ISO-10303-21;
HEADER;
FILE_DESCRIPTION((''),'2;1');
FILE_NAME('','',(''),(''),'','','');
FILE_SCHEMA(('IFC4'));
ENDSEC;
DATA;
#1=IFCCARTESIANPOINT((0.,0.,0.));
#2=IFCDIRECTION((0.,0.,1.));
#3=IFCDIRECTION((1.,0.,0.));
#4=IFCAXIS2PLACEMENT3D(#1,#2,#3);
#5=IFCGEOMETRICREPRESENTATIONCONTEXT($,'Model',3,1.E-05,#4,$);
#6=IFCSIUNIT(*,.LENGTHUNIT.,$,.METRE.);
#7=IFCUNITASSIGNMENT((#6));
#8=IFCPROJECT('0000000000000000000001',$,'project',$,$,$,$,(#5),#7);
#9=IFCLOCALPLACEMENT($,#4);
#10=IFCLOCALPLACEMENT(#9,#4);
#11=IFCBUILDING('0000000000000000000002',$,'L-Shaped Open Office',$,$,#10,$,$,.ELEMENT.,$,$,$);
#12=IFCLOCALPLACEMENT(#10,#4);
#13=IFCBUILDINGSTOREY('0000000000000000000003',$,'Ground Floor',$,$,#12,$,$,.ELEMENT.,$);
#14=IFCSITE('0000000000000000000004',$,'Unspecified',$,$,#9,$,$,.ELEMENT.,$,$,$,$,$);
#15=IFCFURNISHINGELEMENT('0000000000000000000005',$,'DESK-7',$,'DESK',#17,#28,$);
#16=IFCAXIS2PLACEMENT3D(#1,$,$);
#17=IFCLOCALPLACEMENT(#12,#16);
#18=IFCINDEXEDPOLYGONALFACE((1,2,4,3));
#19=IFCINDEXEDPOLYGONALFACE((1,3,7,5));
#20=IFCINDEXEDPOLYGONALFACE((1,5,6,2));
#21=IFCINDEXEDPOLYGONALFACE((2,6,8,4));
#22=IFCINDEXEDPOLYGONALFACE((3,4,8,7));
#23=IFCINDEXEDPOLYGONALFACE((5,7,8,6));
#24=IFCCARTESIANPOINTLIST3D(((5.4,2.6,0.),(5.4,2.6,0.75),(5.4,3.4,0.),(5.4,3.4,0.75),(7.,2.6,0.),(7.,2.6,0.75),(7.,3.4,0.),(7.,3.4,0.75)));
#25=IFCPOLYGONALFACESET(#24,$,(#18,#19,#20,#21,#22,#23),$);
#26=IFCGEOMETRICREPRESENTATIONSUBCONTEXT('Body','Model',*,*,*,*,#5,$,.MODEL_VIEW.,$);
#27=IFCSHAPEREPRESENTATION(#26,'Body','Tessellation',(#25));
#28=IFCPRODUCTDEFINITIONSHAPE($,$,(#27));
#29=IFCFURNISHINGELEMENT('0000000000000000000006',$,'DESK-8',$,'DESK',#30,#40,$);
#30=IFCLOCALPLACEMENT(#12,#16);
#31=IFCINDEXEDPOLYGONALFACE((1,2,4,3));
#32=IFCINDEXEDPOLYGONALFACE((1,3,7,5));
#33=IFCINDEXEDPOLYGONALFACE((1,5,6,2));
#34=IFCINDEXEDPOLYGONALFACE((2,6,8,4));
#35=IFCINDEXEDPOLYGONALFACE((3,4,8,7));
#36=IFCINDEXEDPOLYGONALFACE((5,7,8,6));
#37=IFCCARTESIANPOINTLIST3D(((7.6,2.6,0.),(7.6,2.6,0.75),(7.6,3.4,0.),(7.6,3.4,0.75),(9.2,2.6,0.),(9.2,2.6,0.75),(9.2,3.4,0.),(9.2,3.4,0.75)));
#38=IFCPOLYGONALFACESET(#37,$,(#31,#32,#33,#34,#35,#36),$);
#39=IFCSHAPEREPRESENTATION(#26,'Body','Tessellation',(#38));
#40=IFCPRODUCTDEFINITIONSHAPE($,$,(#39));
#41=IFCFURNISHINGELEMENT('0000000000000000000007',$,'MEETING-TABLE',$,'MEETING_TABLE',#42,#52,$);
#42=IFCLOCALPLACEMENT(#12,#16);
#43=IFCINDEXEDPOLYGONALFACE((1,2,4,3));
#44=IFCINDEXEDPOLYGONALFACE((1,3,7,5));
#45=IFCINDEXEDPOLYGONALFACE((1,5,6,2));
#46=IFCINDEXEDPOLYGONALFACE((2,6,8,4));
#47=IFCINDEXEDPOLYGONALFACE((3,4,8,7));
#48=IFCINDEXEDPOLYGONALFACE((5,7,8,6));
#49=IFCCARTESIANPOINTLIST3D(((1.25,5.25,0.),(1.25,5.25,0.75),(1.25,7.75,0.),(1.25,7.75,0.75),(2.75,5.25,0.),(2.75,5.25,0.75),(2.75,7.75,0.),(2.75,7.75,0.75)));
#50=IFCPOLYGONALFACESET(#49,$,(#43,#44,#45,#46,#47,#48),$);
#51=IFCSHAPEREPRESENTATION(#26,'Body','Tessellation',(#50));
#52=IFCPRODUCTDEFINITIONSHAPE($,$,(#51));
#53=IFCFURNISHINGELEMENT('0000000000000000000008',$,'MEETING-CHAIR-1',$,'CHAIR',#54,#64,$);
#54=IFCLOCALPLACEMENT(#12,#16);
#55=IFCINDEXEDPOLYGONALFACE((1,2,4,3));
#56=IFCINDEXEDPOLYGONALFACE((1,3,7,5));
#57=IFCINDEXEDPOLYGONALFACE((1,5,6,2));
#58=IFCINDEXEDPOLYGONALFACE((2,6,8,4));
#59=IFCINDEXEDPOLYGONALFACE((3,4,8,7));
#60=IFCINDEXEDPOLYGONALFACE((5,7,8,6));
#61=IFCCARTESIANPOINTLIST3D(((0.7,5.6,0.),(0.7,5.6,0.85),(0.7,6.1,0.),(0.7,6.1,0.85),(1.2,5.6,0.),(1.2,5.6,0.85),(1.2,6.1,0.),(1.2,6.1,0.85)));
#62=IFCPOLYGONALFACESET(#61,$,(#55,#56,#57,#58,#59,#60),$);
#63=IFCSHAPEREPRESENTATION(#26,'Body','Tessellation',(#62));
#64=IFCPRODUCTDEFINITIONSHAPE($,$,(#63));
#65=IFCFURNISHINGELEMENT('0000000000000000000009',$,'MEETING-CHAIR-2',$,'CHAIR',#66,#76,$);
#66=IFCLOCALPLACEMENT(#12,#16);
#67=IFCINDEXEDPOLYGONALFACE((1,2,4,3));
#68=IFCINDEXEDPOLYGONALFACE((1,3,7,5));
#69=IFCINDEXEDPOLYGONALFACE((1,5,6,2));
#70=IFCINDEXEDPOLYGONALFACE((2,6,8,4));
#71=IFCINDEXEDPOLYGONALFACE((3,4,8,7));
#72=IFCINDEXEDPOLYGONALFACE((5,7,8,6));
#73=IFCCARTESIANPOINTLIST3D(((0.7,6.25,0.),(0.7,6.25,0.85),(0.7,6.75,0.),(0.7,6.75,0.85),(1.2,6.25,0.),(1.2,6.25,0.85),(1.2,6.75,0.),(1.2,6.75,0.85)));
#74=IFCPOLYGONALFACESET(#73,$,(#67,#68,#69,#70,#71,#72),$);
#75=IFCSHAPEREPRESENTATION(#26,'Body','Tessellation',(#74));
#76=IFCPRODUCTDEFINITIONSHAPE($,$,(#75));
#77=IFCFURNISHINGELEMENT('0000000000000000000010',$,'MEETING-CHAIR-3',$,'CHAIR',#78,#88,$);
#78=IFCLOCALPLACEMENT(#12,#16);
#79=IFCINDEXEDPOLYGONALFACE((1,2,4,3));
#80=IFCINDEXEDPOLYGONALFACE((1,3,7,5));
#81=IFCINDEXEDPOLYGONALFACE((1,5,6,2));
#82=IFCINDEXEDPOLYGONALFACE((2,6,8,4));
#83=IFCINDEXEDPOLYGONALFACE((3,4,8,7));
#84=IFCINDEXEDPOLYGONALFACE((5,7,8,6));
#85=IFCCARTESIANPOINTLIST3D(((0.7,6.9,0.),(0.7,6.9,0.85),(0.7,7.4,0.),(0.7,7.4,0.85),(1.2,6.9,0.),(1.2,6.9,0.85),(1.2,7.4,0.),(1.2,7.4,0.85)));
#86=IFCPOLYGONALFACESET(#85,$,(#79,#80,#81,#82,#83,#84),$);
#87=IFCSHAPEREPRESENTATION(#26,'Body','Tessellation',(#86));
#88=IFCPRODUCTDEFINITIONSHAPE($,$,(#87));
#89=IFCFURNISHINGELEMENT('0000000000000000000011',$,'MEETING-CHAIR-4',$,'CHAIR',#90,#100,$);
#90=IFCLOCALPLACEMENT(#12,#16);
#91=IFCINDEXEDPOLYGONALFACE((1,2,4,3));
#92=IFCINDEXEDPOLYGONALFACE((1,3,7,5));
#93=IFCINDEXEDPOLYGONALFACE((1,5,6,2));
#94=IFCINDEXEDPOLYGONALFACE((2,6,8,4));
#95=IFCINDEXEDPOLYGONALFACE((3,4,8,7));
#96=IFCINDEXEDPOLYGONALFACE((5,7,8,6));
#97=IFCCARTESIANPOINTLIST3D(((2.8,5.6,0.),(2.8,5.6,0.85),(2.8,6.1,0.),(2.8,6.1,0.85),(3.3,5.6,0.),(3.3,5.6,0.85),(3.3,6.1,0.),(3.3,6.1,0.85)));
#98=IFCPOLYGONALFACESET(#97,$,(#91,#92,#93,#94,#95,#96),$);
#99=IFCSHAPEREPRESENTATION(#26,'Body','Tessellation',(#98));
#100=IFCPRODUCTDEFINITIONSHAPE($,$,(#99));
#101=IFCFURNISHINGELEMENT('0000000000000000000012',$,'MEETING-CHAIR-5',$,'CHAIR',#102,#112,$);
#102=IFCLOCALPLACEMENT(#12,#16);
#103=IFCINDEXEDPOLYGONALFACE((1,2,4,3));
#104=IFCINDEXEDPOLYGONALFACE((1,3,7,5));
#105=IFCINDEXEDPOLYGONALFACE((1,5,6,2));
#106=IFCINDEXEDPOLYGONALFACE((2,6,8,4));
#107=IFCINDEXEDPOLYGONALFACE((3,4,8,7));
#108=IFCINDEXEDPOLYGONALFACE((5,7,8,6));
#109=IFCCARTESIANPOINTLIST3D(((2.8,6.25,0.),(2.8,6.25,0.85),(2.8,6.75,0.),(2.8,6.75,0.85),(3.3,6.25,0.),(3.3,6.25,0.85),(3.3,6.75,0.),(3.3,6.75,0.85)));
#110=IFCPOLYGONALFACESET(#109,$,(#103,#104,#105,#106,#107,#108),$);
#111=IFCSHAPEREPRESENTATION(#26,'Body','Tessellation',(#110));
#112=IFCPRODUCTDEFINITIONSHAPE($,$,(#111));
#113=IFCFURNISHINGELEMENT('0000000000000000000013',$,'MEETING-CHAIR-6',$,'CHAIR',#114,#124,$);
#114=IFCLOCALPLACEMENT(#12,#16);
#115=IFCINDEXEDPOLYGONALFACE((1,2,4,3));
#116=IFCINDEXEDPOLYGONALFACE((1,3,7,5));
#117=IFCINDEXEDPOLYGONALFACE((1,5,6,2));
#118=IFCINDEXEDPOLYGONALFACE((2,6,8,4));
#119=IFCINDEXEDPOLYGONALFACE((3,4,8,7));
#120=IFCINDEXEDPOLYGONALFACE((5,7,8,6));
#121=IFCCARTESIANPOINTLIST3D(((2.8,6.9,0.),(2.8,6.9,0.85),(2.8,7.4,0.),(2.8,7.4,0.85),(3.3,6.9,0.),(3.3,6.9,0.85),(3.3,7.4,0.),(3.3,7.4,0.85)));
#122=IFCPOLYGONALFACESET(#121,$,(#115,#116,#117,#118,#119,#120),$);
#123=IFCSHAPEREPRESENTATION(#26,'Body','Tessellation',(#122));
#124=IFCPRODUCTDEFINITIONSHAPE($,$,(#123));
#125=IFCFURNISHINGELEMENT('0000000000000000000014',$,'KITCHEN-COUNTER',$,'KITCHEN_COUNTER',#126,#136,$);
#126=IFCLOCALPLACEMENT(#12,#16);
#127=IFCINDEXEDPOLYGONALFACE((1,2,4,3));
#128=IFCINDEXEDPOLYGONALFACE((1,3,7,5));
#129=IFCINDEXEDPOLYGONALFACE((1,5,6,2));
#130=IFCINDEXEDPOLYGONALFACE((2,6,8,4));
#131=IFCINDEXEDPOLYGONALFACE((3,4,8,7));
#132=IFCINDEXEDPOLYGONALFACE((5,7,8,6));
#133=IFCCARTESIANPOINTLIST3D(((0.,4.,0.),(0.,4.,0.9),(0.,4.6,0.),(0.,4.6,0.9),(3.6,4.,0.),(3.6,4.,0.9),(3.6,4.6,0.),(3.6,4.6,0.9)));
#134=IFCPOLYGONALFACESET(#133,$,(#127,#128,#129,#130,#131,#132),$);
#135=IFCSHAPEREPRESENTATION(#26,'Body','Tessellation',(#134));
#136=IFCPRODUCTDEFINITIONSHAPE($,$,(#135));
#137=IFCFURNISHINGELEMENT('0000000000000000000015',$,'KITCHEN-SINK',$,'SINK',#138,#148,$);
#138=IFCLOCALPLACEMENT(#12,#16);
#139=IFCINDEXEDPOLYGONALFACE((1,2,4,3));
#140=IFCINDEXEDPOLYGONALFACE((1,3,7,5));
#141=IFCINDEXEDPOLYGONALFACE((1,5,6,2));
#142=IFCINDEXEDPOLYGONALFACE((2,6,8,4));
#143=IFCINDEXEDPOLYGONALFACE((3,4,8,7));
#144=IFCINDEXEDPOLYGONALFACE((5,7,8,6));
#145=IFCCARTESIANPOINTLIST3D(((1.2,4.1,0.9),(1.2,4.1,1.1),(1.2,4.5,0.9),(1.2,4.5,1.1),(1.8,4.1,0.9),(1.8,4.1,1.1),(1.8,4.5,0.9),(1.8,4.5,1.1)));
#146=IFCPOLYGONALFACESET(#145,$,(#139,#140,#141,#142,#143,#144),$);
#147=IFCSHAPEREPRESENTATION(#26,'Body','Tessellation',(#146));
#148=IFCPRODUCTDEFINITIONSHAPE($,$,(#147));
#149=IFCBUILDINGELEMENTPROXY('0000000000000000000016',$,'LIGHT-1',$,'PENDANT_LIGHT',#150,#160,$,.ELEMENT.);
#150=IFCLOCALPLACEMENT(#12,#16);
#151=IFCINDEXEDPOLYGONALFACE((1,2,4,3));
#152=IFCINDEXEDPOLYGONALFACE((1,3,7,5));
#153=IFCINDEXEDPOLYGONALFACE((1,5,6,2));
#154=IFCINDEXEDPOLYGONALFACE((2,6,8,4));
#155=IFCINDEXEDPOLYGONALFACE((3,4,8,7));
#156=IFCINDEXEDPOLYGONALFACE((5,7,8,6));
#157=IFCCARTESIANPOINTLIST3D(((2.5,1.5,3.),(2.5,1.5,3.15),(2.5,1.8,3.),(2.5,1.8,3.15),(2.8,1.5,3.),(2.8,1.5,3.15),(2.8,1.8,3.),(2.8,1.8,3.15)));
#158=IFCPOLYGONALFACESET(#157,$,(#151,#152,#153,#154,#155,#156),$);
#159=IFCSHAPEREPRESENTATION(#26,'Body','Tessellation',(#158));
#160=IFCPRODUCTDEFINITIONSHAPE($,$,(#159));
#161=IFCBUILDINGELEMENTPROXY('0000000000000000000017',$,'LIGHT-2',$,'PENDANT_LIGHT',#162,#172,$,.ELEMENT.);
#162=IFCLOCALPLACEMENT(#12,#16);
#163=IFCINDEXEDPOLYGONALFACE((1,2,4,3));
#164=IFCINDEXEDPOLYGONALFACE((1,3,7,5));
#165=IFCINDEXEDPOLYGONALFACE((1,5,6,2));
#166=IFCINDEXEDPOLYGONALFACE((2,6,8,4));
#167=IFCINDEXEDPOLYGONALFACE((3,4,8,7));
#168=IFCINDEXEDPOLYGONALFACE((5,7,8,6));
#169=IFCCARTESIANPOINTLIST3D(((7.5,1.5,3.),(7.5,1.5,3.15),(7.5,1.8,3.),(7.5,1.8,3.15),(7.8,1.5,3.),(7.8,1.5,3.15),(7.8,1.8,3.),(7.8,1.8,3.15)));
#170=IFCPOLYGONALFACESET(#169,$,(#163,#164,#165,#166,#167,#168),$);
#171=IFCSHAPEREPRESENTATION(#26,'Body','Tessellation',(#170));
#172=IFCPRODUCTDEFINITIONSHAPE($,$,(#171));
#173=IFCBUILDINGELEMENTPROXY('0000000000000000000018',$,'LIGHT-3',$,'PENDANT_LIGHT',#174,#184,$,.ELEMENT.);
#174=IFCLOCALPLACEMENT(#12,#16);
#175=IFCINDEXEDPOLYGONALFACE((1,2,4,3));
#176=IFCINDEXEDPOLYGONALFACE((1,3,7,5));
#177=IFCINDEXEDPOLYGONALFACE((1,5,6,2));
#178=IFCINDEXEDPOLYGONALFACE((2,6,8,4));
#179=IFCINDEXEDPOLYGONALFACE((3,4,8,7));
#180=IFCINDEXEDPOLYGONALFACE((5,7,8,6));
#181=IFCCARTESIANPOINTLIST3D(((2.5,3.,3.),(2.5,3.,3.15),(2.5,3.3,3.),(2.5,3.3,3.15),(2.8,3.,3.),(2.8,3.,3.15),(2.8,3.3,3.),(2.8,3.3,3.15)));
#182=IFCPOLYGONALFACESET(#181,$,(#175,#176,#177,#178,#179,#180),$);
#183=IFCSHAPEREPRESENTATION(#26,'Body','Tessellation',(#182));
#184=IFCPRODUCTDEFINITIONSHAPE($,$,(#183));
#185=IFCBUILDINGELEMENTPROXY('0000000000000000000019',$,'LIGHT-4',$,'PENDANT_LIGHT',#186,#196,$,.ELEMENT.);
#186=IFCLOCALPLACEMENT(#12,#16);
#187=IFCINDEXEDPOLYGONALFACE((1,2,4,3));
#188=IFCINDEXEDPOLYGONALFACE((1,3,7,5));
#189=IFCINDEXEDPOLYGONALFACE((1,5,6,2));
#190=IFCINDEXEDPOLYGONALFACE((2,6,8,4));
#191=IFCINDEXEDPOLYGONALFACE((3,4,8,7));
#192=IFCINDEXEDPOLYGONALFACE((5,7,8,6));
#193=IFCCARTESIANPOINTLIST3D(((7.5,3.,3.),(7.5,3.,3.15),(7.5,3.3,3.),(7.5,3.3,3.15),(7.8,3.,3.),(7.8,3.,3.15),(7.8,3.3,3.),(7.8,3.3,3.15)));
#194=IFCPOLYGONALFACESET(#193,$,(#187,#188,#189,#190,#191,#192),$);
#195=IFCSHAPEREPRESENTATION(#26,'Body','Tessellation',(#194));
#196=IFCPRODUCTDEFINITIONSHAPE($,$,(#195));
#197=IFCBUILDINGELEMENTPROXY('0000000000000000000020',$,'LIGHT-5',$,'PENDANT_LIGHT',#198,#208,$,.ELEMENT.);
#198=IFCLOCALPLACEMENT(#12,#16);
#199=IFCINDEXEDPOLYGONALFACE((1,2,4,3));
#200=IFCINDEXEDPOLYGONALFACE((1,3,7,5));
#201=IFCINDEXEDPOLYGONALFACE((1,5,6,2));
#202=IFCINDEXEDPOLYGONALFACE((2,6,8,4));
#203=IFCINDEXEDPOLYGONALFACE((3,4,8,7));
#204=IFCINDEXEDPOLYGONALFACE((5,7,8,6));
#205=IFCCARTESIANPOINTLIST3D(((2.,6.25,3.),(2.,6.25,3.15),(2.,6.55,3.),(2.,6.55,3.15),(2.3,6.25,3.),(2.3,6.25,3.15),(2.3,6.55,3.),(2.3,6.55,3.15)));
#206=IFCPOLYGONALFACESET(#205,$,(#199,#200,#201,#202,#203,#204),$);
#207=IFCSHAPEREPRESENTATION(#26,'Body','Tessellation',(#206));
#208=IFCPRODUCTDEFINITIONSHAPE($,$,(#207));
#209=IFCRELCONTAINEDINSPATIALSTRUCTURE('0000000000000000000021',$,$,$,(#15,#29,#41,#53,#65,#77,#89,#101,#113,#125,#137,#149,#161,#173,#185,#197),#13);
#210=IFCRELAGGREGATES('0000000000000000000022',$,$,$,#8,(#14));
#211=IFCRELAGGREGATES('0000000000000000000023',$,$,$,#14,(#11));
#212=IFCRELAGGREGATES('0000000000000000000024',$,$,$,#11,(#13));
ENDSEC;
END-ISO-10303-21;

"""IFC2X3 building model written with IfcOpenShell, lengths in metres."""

from ifc_helpers import new_model, si_unit, frame, frame_2d, origin, origin_with_axes, place, context, subcontext, project, spatial, rectangle, extrude, element, save


model = new_model("IFC2X3")

# Units and contexts
model_context = context("Model", 3, precision=1e-05, world=origin_with_axes())
body_context = subcontext(model_context, "Body", "Model", "MODEL_VIEW")
ifc_project = project(units=[si_unit("LENGTHUNIT", "METRE")], contexts=[model_context])

# Site, building, storey
site_placement = place(None, origin_with_axes())
site = spatial("IfcSite", under=ifc_project, at=site_placement, Name="Unspecified", CompositionType="ELEMENT")
building_placement = place(site_placement, origin_with_axes())
building = spatial("IfcBuilding", under=site, at=building_placement, Name="L-Shaped Open Office", CompositionType="ELEMENT")
storey_placement = place(building_placement, origin_with_axes())
storey = spatial("IfcBuildingStorey", under=building, at=storey_placement, Name="Ground Floor", CompositionType="ELEMENT")

# Furnishing elements
for number, where, z_axis, x_axis, name in (
    (1, (5.4, 2.6, 0.0), (0.0, 0.0, 1.0), (1.0, 0.0, 0.0), "DESK-7"),
    (2, (7.6, 2.6, 0.0), (0.0, 0.0, 1.0), (1.0, 0.0, 0.0), "DESK-8"),
):
    element("IfcFurnishingElement", number, at=place(storey_placement, frame(where, z_axis=z_axis, x_axis=x_axis)), inside=storey, Name=name, ObjectType="DESK", context=body_context, shape_type="SweptSolid", body=[
        extrude(rectangle(XDim=1.6, YDim=0.8, at=frame_2d((0.8, 0.4))), origin(), (0.0, 0.0, 1.0), 0.75),
    ])
furnishing_1_placement = place(storey_placement, frame((1.25, 5.25, 0.0), z_axis=(0.0, 0.0, 1.0), x_axis=(1.0, 0.0, 0.0)))
element("IfcFurnishingElement", 3, at=furnishing_1_placement, inside=storey, Name="MEETING-TABLE", ObjectType="MEETING_TABLE", context=body_context, shape_type="SweptSolid", body=[
    extrude(rectangle(XDim=1.5, YDim=2.5, at=frame_2d((0.75, 1.25))), origin(), (0.0, 0.0, 1.0), 0.75),
])
for number, where, z_axis, x_axis, name in (
    (4, (0.7, 5.6, 0.0), (0.0, 0.0, 1.0), (1.0, 0.0, 0.0), "MEETING-CHAIR-1"),
    (5, (0.7, 6.25, 0.0), (0.0, 0.0, 1.0), (1.0, 0.0, 0.0), "MEETING-CHAIR-2"),
    (6, (0.7, 6.9, 0.0), (0.0, 0.0, 1.0), (1.0, 0.0, 0.0), "MEETING-CHAIR-3"),
    (7, (2.8, 5.6, 0.0), (0.0, 0.0, 1.0), (1.0, 0.0, 0.0), "MEETING-CHAIR-4"),
    (8, (2.8, 6.25, 0.0), (0.0, 0.0, 1.0), (1.0, 0.0, 0.0), "MEETING-CHAIR-5"),
    (9, (2.8, 6.9, 0.0), (0.0, 0.0, 1.0), (1.0, 0.0, 0.0), "MEETING-CHAIR-6"),
):
    element("IfcFurnishingElement", number, at=place(storey_placement, frame(where, z_axis=z_axis, x_axis=x_axis)), inside=storey, Name=name, ObjectType="CHAIR", context=body_context, shape_type="SweptSolid", body=[
        extrude(rectangle(XDim=0.5, YDim=0.5, at=frame_2d((0.25, 0.25))), origin(), (0.0, 0.0, 1.0), 0.85),
    ])
furnishing_2_placement = place(storey_placement, frame((0.0, 4.0, 0.0), z_axis=(0.0, 0.0, 1.0), x_axis=(1.0, 0.0, 0.0)))
element("IfcFurnishingElement", 10, at=furnishing_2_placement, inside=storey, Name="KITCHEN-COUNTER", ObjectType="KITCHEN_COUNTER", context=body_context, shape_type="SweptSolid", body=[
    extrude(rectangle(XDim=3.6, YDim=0.6, at=frame_2d((1.8, 0.3))), origin(), (0.0, 0.0, 1.0), 0.9),
])
furnishing_3_placement = place(storey_placement, frame((1.2, 4.1, 0.9), z_axis=(0.0, 0.0, 1.0), x_axis=(1.0, 0.0, 0.0)))
element("IfcFurnishingElement", 11, at=furnishing_3_placement, inside=storey, Name="KITCHEN-SINK", ObjectType="SINK", context=body_context, shape_type="SweptSolid", body=[
    extrude(rectangle(XDim=0.6, YDim=0.4, at=frame_2d((0.3, 0.2))), origin(), (0.0, 0.0, 1.0), 0.2),
])

# Building element proxies
for number, where, z_axis, x_axis, name in (
    (12, (2.5, 1.5, 3.0), (0.0, 0.0, 1.0), (1.0, 0.0, 0.0), "LIGHT-1"),
    (13, (7.5, 1.5, 3.0), (0.0, 0.0, 1.0), (1.0, 0.0, 0.0), "LIGHT-2"),
    (14, (2.5, 3.0, 3.0), (0.0, 0.0, 1.0), (1.0, 0.0, 0.0), "LIGHT-3"),
    (15, (7.5, 3.0, 3.0), (0.0, 0.0, 1.0), (1.0, 0.0, 0.0), "LIGHT-4"),
    (16, (2.0, 6.25, 3.0), (0.0, 0.0, 1.0), (1.0, 0.0, 0.0), "LIGHT-5"),
):
    element("IfcBuildingElementProxy", number, at=place(storey_placement, frame(where, z_axis=z_axis, x_axis=x_axis)), inside=storey, Name=name, ObjectType="PENDANT_LIGHT", CompositionType="ELEMENT", context=body_context, shape_type="SweptSolid", body=[
        extrude(rectangle(XDim=0.3, YDim=0.3, at=frame_2d((0.15, 0.15))), origin(), (0.0, 0.0, 1.0), 0.15),
    ])

save(model, "model.ifc")
